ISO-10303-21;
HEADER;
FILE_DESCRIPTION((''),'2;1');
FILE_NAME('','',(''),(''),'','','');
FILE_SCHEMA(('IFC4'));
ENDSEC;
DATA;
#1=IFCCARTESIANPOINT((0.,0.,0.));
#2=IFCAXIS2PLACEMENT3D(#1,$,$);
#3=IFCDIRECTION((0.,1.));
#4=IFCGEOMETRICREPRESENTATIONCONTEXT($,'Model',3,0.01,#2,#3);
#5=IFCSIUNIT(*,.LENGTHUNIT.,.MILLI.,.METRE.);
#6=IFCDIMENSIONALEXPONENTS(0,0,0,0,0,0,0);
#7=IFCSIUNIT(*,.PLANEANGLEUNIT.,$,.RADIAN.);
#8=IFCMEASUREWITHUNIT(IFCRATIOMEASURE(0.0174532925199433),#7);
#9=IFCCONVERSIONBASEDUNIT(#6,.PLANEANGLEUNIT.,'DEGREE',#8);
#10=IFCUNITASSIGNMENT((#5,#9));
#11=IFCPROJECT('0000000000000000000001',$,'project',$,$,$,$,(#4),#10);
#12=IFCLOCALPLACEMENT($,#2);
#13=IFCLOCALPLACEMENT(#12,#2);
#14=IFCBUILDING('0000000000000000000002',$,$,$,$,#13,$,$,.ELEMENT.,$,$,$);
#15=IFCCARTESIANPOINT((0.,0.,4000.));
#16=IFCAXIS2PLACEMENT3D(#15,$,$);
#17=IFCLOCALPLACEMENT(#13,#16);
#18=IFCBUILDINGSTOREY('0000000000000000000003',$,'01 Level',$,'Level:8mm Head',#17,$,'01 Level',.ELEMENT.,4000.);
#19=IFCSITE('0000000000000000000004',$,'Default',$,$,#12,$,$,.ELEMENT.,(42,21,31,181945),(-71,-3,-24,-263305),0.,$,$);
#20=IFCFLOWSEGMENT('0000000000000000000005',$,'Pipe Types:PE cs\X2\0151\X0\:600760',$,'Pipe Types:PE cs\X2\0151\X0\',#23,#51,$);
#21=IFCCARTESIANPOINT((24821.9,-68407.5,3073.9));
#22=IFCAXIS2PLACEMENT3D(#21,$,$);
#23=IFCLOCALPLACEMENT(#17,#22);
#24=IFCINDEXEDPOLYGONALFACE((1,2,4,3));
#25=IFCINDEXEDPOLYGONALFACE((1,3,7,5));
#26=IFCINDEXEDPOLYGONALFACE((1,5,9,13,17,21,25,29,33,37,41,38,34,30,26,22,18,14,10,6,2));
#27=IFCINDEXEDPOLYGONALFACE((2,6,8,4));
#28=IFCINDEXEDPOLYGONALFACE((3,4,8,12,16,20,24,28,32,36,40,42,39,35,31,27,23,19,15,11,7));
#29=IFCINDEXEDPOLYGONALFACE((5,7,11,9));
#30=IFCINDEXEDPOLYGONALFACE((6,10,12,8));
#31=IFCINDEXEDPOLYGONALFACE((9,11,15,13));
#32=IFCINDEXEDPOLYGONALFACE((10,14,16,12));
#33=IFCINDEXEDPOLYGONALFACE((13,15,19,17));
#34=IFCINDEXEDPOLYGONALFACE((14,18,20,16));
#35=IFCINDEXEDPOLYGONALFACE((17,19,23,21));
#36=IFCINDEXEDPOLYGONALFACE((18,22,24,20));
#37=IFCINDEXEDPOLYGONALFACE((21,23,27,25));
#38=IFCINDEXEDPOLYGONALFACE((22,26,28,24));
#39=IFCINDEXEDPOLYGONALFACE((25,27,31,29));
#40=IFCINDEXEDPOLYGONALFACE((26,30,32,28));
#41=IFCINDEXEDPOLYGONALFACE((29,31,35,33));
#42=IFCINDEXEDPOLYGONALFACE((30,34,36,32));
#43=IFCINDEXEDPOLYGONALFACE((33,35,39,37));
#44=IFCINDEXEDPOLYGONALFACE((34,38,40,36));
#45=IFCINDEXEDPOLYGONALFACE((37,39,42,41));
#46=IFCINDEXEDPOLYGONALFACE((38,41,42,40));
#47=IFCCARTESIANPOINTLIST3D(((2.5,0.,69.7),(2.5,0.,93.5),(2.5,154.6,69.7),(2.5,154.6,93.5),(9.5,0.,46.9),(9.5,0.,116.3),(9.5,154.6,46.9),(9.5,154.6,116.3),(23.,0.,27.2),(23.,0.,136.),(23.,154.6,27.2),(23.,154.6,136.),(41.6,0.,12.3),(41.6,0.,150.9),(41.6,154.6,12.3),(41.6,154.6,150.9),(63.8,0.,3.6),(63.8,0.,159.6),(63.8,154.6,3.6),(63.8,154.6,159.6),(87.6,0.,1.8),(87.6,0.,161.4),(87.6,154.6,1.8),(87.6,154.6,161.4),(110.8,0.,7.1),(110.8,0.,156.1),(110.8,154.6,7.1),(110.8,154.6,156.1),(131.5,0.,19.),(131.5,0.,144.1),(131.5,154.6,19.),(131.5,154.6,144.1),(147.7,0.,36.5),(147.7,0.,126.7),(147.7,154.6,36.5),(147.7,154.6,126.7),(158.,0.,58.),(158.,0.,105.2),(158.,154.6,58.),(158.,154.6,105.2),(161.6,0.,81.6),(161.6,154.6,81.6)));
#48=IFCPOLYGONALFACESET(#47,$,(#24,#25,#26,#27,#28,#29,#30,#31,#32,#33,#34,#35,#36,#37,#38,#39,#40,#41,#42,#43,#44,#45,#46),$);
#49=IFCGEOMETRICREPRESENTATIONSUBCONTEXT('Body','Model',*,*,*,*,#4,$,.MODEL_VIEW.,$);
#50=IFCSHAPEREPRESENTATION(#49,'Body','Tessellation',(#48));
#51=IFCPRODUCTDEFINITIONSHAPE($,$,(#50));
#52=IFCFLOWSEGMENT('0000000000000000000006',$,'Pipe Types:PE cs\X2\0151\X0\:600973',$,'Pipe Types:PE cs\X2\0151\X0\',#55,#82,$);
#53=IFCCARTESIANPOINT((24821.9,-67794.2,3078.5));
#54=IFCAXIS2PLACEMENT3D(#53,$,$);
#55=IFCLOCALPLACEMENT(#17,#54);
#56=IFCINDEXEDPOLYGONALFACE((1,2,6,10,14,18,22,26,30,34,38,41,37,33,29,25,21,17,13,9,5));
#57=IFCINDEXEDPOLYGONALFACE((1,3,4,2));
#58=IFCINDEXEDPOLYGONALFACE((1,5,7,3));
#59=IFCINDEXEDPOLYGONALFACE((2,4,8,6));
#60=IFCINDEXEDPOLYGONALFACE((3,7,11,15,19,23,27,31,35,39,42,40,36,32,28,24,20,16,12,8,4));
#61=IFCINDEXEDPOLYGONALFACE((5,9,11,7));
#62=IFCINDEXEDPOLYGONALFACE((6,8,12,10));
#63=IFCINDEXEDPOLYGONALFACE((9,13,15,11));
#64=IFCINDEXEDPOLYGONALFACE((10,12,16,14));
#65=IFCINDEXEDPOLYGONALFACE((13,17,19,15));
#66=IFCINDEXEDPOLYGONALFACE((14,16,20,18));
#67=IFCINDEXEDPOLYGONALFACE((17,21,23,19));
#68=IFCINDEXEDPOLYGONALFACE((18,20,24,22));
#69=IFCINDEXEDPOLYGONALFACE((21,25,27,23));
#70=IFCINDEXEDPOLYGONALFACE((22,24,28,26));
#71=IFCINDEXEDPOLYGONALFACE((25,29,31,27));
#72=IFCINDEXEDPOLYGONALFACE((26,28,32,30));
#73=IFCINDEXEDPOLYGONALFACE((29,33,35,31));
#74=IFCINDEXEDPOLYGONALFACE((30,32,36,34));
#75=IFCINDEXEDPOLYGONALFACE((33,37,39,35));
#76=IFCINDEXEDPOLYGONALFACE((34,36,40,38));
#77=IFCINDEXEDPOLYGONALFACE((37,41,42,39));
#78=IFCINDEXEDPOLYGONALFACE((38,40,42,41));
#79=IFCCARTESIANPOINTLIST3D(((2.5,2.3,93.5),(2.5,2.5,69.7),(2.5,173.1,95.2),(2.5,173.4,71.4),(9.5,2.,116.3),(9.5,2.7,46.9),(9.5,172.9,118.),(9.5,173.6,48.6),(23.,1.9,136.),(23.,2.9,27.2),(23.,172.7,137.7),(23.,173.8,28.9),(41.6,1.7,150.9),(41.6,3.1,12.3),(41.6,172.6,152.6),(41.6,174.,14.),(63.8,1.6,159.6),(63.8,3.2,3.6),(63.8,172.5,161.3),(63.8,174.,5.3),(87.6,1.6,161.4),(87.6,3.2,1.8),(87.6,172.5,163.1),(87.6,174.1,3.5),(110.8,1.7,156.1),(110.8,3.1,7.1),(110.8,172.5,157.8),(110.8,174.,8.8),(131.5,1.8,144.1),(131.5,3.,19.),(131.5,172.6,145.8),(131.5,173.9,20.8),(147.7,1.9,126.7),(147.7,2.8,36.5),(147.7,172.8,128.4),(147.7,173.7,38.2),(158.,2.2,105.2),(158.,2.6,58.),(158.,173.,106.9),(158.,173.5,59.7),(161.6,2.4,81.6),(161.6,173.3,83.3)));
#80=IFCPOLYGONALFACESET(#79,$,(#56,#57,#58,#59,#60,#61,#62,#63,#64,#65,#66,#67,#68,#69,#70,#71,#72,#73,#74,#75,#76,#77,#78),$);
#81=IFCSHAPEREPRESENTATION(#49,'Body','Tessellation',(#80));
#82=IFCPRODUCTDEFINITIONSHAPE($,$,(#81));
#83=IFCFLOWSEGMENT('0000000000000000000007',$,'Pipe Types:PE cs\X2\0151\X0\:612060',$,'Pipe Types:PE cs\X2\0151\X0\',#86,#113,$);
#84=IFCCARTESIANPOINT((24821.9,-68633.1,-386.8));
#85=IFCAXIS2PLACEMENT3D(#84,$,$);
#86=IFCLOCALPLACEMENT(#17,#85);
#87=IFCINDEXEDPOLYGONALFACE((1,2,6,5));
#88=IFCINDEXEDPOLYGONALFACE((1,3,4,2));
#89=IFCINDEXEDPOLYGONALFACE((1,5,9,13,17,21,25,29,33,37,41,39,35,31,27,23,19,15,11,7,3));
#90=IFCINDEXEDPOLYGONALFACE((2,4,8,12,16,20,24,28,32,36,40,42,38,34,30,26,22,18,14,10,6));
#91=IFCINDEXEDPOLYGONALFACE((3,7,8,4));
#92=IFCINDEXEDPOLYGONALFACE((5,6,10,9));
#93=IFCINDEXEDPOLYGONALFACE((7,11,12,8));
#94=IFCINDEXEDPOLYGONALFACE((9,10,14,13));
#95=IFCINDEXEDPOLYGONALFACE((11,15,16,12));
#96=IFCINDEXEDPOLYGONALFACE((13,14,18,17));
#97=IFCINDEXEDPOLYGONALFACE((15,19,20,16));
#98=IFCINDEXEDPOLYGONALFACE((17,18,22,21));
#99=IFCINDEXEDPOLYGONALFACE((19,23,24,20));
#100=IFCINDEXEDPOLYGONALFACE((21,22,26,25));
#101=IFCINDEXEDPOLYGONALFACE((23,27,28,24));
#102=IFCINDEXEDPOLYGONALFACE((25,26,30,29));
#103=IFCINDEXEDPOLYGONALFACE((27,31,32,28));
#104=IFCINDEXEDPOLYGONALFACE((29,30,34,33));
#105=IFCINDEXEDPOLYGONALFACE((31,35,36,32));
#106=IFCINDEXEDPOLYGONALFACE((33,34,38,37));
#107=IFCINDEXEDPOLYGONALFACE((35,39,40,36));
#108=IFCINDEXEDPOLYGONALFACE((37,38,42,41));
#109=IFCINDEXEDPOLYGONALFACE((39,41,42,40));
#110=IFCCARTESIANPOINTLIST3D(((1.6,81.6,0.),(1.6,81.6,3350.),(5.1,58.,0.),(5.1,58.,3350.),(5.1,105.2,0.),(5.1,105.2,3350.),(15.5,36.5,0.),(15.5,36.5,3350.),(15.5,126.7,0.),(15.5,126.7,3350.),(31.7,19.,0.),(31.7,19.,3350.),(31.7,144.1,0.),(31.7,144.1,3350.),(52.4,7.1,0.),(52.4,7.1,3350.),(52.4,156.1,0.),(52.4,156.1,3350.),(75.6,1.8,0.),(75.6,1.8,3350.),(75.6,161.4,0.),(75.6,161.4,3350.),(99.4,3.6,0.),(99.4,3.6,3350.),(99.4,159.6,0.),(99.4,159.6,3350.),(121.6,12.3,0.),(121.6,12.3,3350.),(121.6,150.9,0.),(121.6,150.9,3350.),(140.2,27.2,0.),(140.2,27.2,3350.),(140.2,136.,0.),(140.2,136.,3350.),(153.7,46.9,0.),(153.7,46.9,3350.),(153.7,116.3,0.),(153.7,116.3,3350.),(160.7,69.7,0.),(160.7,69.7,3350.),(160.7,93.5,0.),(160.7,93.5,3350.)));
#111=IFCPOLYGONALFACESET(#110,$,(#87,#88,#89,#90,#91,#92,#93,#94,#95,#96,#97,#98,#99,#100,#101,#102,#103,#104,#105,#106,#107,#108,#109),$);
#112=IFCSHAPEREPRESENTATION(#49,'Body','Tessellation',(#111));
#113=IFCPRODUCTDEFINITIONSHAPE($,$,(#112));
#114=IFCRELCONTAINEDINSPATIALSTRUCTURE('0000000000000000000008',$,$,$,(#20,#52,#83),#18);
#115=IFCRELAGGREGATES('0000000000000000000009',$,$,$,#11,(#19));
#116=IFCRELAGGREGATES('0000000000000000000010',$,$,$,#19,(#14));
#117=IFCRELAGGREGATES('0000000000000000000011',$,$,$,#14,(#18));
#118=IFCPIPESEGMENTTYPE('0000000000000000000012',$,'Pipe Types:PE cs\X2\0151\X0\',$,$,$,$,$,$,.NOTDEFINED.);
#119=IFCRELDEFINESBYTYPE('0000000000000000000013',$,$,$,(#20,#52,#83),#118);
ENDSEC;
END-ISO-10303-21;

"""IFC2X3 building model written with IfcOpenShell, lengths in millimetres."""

from ifc_helpers import new_model, entity, si_unit, converted_unit, direction, frame, origin, origin_2d_with_axis, place, context, subcontext, project, spatial, circle, extrude, type_object, element, save


model = new_model("IFC2X3")

# Units and contexts
model_context = context("Model", 3, precision=0.01, world=origin(), true_north=direction((0.0, 1.0)))
body_context = subcontext(model_context, "Body", "Model", "MODEL_VIEW")
ifc_project = project(units=[si_unit("LENGTHUNIT", "METRE", prefix="MILLI"), converted_unit("PLANEANGLEUNIT", "DEGREE", entity("IfcRatioMeasure", 0.0174532925199433), si_unit("PLANEANGLEUNIT", "RADIAN"), dimensions=[0, 0, 0, 0, 0, 0, 0])], contexts=[model_context])

# Site, building, storey
site_placement = place(None, origin())
site = spatial("IfcSite", under=ifc_project, at=site_placement, Name="Default", CompositionType="ELEMENT", RefLatitude=(42, 21, 31, 181945), RefLongitude=(-71, -3, -24, -263305), RefElevation=0.0)
building_placement = place(site_placement, origin())
building = spatial("IfcBuilding", under=site, at=building_placement, CompositionType="ELEMENT")
storey_placement = place(building_placement, frame((0.0, 0.0, 4000.0)))
storey = spatial("IfcBuildingStorey", under=building, at=storey_placement, Name="01 Level", ObjectType="Level:8mm Head", LongName="01 Level", CompositionType="ELEMENT", Elevation=4000.0)

# Flow segments
pipe_segment_type = type_object("IfcPipeSegmentType", Name="Pipe Types:PE cső", PredefinedType="NOTDEFINED")
flow_segment_1_placement = place(storey_placement, frame((24821.9, -68407.5, 3073.9)))
element("IfcFlowSegment", 1, at=flow_segment_1_placement, inside=storey, type_object=pipe_segment_type, Name="Pipe Types:PE cső:600760", ObjectType="Pipe Types:PE cső", context=body_context, shape_type="SweptSolid", body=[
    extrude(circle(Radius=80.0, at=origin_2d_with_axis()), frame((81.6, 0.0, 81.6), z_axis=(0.0, 1.0, 0.0), x_axis=(1.0, 0.0, 0.0)), (0.0, 0.0, 1.0), 154.6),
])
flow_segment_2_placement = place(storey_placement, frame((24821.9, -67794.2, 3078.5)))
element("IfcFlowSegment", 2, at=flow_segment_2_placement, inside=storey, type_object=pipe_segment_type, Name="Pipe Types:PE cső:600973", ObjectType="Pipe Types:PE cső", context=body_context, shape_type="SweptSolid", body=[
    extrude(circle(Radius=80.0, at=origin_2d_with_axis()), frame((81.6, 2.4, 81.6), z_axis=(0.0, 0.99995, 0.01), x_axis=(1.0, 0.0, 0.0)), (0.0, 0.0, 1.0), 170.9),
])
flow_segment_3_placement = place(storey_placement, frame((24821.9, -68633.1, -386.8)))
element("IfcFlowSegment", 3, at=flow_segment_3_placement, inside=storey, type_object=pipe_segment_type, Name="Pipe Types:PE cső:612060", ObjectType="Pipe Types:PE cső", context=body_context, shape_type="SweptSolid", body=[
    extrude(circle(Radius=80.0, at=origin_2d_with_axis()), frame((81.6, 81.6, 0.0), z_axis=(0.0, 0.0, 1.0), x_axis=(-1.0, 0.0, 0.0)), (0.0, 0.0, 1.0), 3350.0),
])

save(model, "model.ifc")
